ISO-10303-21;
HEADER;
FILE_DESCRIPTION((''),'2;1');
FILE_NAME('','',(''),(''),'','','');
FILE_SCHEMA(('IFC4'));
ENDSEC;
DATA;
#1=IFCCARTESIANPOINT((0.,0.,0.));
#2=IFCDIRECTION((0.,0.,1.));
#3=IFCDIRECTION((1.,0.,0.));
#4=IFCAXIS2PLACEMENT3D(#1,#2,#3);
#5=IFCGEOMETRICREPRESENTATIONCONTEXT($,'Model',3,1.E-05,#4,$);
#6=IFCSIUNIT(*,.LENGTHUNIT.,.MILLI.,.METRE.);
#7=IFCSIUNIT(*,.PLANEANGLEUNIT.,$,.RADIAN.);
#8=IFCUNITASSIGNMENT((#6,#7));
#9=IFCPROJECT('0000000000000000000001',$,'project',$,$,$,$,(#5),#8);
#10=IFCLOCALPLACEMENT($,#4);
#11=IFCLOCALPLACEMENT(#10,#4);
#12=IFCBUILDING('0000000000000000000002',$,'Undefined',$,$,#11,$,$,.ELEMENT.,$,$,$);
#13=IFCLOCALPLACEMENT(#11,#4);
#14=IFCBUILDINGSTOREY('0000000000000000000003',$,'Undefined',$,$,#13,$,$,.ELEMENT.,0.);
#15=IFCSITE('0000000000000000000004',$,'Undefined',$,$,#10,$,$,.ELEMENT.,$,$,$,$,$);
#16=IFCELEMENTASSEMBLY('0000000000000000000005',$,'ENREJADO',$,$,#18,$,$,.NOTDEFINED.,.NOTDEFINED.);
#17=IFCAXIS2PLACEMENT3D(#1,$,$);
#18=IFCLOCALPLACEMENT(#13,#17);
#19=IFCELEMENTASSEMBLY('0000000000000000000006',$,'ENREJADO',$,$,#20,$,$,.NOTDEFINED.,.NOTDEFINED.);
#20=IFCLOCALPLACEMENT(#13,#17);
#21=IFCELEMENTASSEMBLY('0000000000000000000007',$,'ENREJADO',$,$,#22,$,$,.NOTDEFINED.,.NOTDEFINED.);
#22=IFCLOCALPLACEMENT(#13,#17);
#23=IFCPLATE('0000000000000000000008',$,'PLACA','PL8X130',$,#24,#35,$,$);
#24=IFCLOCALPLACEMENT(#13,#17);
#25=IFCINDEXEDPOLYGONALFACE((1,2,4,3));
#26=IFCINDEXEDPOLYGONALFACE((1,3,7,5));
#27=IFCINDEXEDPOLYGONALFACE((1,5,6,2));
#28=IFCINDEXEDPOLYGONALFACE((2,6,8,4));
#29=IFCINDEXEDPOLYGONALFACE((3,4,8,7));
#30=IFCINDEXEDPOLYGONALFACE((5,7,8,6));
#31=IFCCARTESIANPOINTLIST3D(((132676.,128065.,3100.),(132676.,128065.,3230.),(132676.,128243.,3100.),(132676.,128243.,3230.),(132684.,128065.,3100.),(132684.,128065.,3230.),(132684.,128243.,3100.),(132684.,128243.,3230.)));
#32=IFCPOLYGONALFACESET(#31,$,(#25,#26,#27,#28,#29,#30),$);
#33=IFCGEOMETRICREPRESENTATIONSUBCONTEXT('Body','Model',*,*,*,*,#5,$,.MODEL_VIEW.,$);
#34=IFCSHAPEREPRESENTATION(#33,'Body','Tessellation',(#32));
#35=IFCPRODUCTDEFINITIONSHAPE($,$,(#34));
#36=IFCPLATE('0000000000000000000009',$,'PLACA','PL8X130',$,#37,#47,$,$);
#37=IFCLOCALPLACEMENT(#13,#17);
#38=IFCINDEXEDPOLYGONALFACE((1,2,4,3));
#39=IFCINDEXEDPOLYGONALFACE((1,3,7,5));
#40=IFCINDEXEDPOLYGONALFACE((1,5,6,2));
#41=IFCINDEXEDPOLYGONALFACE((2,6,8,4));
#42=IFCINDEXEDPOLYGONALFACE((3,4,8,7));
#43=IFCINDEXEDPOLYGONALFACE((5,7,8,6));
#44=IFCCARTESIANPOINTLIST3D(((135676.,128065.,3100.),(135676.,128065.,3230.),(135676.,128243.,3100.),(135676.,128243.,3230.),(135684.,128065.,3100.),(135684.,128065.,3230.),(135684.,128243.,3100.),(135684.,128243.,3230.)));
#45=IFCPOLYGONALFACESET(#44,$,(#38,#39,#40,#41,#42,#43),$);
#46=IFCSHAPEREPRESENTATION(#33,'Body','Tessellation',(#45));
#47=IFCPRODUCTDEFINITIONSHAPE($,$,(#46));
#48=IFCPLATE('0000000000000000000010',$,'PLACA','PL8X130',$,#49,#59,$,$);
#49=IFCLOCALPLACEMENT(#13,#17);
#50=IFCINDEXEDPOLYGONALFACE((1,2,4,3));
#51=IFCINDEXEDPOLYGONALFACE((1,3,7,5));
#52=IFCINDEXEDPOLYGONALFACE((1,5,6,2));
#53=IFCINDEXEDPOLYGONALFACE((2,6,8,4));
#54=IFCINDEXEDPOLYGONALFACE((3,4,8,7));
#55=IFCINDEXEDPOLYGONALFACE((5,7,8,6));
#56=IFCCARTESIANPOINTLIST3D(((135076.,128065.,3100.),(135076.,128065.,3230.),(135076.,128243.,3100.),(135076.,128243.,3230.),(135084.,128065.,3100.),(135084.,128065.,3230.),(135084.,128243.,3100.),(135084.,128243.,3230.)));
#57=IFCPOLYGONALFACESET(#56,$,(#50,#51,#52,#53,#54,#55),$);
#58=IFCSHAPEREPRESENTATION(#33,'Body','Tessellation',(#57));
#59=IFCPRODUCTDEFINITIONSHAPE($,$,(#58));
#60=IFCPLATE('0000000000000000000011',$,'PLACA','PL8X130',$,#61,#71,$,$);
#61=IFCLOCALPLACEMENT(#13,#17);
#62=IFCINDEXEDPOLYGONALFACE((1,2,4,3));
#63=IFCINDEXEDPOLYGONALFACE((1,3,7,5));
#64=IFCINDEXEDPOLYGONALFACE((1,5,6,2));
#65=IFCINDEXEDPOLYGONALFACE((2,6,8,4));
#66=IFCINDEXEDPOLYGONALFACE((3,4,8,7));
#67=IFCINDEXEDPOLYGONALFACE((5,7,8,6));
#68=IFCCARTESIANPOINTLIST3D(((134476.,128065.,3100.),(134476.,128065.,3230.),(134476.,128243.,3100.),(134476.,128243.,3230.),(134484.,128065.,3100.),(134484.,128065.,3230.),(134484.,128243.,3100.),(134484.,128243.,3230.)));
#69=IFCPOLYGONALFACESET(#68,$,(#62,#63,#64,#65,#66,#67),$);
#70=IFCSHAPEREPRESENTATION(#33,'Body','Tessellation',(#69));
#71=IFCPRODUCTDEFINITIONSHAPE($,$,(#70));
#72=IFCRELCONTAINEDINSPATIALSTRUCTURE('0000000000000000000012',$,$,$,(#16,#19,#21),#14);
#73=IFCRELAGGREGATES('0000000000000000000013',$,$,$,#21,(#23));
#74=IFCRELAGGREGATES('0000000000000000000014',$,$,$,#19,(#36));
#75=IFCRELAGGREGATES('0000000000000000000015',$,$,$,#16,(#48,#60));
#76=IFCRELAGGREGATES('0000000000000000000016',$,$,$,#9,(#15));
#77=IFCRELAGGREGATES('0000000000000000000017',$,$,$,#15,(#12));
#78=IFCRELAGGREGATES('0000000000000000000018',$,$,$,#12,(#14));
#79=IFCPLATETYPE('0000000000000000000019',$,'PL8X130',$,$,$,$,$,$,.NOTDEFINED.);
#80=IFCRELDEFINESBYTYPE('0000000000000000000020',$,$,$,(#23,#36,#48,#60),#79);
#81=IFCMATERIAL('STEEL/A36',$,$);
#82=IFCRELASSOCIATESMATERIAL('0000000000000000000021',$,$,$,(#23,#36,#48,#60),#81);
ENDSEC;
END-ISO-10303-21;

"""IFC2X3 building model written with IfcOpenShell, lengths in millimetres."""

from ifc_helpers import new_model, si_unit, frame, origin_with_axes, place, context, subcontext, project, spatial, polyline, outline, extrude, material, type_object, element, aggregate, save


model = new_model("IFC2X3")

# Units and contexts
model_context = context("Model", 3, precision=1e-05, world=origin_with_axes())
body_context = subcontext(model_context, "Body", "Model", "MODEL_VIEW")
ifc_project = project(units=[si_unit("LENGTHUNIT", "METRE", prefix="MILLI"), si_unit("PLANEANGLEUNIT", "RADIAN")], contexts=[model_context])

# Site, building, storey
site_placement = place(None, origin_with_axes())
site = spatial("IfcSite", under=ifc_project, at=site_placement, Name="Undefined", CompositionType="ELEMENT")
building_placement = place(site_placement, origin_with_axes())
building = spatial("IfcBuilding", under=site, at=building_placement, Name="Undefined", CompositionType="ELEMENT")
storey_placement = place(building_placement, origin_with_axes())
storey = spatial("IfcBuildingStorey", under=building, at=storey_placement, Name="Undefined", CompositionType="ELEMENT", Elevation=0.0)

# Shared definitions
ifc_material_1 = material(Name="STEEL/A36")

# Element assembly
assembly_1_placement = place(storey_placement, origin_with_axes())
assembly_1 = element("IfcElementAssembly", 1, at=assembly_1_placement, inside=storey, Name="ENREJADO", AssemblyPlace="NOTDEFINED", PredefinedType="NOTDEFINED")

# Element assembly
assembly_2_placement = place(storey_placement, origin_with_axes())
assembly_2 = element("IfcElementAssembly", 2, at=assembly_2_placement, inside=storey, Name="ENREJADO", AssemblyPlace="NOTDEFINED", PredefinedType="NOTDEFINED")

# Element assembly
assembly_3_placement = place(storey_placement, origin_with_axes())
assembly_3 = element("IfcElementAssembly", 3, at=assembly_3_placement, inside=storey, Name="ENREJADO", AssemblyPlace="NOTDEFINED", PredefinedType="NOTDEFINED")

# Plates
plate_type_1 = type_object("IfcPlateType", Name="PL8X130", PredefinedType="NOTDEFINED")
plate_1_placement = place(assembly_3_placement, frame((132680.0, 128065.0, 3165.0), z_axis=(-1.0, 0.000001, 0.0), x_axis=(0.000001, 1.0, 0.0)))
plate_1 = element("IfcPlate", 4, at=plate_1_placement, type_object=plate_type_1, material=ifc_material_1, Name="PLACA", Description="PL8X130", context=body_context, shape_type="SweptSolid", body=[
    extrude(outline(polyline([(0.0, -65.0), (0.0, 65.0), (178.0, 65.0), (178.0, -65.0), (0.0, -65.0)])), frame((0.0, 0.0, -4.0), z_axis=(0.0, 0.0, 1.0), x_axis=(1.0, 0.0, 0.0)), (0.0, 0.0, 1.0), 8.0),
])
aggregate(assembly_3, [plate_1])
plate_2_placement = place(assembly_2_placement, frame((135680.0, 128065.0, 3165.0), z_axis=(-1.0, 0.000001, 0.0), x_axis=(0.000001, 1.0, 0.0)))
plate_2 = element("IfcPlate", 5, at=plate_2_placement, type_object=plate_type_1, material=ifc_material_1, Name="PLACA", Description="PL8X130", context=body_context, shape_type="SweptSolid", body=[
    extrude(outline(polyline([(0.0, -65.0), (0.0, 65.0), (178.0, 65.0), (178.0, -65.0), (0.0, -65.0)])), frame((0.0, 0.0, -4.0), z_axis=(0.0, 0.0, 1.0), x_axis=(1.0, 0.0, 0.0)), (0.0, 0.0, 1.0), 8.0),
])
aggregate(assembly_2, [plate_2])
plate_3_placement = place(assembly_1_placement, frame((135080.0, 128065.0, 3165.0), z_axis=(-1.0, 0.000001, 0.0), x_axis=(0.000001, 1.0, 0.0)))
plate_3 = element("IfcPlate", 6, at=plate_3_placement, type_object=plate_type_1, material=ifc_material_1, Name="PLACA", Description="PL8X130", context=body_context, shape_type="SweptSolid", body=[
    extrude(outline(polyline([(0.0, -65.0), (0.0, 65.0), (178.0, 65.0), (178.0, -65.0), (0.0, -65.0)])), frame((0.0, 0.0, -4.0), z_axis=(0.0, 0.0, 1.0), x_axis=(1.0, 0.0, 0.0)), (0.0, 0.0, 1.0), 8.0),
])
plate_4_placement = place(assembly_1_placement, frame((134480.0, 128065.0, 3165.0), z_axis=(-1.0, 0.000001, 0.0), x_axis=(0.000001, 1.0, 0.0)))
plate_4 = element("IfcPlate", 7, at=plate_4_placement, type_object=plate_type_1, material=ifc_material_1, Name="PLACA", Description="PL8X130", context=body_context, shape_type="SweptSolid", body=[
    extrude(outline(polyline([(0.0, -65.0), (0.0, 65.0), (178.0, 65.0), (178.0, -65.0), (0.0, -65.0)])), frame((0.0, 0.0, -4.0), z_axis=(0.0, 0.0, 1.0), x_axis=(1.0, 0.0, 0.0)), (0.0, 0.0, 1.0), 8.0),
])
aggregate(assembly_1, [plate_3, plate_4])

save(model, "model.ifc")
